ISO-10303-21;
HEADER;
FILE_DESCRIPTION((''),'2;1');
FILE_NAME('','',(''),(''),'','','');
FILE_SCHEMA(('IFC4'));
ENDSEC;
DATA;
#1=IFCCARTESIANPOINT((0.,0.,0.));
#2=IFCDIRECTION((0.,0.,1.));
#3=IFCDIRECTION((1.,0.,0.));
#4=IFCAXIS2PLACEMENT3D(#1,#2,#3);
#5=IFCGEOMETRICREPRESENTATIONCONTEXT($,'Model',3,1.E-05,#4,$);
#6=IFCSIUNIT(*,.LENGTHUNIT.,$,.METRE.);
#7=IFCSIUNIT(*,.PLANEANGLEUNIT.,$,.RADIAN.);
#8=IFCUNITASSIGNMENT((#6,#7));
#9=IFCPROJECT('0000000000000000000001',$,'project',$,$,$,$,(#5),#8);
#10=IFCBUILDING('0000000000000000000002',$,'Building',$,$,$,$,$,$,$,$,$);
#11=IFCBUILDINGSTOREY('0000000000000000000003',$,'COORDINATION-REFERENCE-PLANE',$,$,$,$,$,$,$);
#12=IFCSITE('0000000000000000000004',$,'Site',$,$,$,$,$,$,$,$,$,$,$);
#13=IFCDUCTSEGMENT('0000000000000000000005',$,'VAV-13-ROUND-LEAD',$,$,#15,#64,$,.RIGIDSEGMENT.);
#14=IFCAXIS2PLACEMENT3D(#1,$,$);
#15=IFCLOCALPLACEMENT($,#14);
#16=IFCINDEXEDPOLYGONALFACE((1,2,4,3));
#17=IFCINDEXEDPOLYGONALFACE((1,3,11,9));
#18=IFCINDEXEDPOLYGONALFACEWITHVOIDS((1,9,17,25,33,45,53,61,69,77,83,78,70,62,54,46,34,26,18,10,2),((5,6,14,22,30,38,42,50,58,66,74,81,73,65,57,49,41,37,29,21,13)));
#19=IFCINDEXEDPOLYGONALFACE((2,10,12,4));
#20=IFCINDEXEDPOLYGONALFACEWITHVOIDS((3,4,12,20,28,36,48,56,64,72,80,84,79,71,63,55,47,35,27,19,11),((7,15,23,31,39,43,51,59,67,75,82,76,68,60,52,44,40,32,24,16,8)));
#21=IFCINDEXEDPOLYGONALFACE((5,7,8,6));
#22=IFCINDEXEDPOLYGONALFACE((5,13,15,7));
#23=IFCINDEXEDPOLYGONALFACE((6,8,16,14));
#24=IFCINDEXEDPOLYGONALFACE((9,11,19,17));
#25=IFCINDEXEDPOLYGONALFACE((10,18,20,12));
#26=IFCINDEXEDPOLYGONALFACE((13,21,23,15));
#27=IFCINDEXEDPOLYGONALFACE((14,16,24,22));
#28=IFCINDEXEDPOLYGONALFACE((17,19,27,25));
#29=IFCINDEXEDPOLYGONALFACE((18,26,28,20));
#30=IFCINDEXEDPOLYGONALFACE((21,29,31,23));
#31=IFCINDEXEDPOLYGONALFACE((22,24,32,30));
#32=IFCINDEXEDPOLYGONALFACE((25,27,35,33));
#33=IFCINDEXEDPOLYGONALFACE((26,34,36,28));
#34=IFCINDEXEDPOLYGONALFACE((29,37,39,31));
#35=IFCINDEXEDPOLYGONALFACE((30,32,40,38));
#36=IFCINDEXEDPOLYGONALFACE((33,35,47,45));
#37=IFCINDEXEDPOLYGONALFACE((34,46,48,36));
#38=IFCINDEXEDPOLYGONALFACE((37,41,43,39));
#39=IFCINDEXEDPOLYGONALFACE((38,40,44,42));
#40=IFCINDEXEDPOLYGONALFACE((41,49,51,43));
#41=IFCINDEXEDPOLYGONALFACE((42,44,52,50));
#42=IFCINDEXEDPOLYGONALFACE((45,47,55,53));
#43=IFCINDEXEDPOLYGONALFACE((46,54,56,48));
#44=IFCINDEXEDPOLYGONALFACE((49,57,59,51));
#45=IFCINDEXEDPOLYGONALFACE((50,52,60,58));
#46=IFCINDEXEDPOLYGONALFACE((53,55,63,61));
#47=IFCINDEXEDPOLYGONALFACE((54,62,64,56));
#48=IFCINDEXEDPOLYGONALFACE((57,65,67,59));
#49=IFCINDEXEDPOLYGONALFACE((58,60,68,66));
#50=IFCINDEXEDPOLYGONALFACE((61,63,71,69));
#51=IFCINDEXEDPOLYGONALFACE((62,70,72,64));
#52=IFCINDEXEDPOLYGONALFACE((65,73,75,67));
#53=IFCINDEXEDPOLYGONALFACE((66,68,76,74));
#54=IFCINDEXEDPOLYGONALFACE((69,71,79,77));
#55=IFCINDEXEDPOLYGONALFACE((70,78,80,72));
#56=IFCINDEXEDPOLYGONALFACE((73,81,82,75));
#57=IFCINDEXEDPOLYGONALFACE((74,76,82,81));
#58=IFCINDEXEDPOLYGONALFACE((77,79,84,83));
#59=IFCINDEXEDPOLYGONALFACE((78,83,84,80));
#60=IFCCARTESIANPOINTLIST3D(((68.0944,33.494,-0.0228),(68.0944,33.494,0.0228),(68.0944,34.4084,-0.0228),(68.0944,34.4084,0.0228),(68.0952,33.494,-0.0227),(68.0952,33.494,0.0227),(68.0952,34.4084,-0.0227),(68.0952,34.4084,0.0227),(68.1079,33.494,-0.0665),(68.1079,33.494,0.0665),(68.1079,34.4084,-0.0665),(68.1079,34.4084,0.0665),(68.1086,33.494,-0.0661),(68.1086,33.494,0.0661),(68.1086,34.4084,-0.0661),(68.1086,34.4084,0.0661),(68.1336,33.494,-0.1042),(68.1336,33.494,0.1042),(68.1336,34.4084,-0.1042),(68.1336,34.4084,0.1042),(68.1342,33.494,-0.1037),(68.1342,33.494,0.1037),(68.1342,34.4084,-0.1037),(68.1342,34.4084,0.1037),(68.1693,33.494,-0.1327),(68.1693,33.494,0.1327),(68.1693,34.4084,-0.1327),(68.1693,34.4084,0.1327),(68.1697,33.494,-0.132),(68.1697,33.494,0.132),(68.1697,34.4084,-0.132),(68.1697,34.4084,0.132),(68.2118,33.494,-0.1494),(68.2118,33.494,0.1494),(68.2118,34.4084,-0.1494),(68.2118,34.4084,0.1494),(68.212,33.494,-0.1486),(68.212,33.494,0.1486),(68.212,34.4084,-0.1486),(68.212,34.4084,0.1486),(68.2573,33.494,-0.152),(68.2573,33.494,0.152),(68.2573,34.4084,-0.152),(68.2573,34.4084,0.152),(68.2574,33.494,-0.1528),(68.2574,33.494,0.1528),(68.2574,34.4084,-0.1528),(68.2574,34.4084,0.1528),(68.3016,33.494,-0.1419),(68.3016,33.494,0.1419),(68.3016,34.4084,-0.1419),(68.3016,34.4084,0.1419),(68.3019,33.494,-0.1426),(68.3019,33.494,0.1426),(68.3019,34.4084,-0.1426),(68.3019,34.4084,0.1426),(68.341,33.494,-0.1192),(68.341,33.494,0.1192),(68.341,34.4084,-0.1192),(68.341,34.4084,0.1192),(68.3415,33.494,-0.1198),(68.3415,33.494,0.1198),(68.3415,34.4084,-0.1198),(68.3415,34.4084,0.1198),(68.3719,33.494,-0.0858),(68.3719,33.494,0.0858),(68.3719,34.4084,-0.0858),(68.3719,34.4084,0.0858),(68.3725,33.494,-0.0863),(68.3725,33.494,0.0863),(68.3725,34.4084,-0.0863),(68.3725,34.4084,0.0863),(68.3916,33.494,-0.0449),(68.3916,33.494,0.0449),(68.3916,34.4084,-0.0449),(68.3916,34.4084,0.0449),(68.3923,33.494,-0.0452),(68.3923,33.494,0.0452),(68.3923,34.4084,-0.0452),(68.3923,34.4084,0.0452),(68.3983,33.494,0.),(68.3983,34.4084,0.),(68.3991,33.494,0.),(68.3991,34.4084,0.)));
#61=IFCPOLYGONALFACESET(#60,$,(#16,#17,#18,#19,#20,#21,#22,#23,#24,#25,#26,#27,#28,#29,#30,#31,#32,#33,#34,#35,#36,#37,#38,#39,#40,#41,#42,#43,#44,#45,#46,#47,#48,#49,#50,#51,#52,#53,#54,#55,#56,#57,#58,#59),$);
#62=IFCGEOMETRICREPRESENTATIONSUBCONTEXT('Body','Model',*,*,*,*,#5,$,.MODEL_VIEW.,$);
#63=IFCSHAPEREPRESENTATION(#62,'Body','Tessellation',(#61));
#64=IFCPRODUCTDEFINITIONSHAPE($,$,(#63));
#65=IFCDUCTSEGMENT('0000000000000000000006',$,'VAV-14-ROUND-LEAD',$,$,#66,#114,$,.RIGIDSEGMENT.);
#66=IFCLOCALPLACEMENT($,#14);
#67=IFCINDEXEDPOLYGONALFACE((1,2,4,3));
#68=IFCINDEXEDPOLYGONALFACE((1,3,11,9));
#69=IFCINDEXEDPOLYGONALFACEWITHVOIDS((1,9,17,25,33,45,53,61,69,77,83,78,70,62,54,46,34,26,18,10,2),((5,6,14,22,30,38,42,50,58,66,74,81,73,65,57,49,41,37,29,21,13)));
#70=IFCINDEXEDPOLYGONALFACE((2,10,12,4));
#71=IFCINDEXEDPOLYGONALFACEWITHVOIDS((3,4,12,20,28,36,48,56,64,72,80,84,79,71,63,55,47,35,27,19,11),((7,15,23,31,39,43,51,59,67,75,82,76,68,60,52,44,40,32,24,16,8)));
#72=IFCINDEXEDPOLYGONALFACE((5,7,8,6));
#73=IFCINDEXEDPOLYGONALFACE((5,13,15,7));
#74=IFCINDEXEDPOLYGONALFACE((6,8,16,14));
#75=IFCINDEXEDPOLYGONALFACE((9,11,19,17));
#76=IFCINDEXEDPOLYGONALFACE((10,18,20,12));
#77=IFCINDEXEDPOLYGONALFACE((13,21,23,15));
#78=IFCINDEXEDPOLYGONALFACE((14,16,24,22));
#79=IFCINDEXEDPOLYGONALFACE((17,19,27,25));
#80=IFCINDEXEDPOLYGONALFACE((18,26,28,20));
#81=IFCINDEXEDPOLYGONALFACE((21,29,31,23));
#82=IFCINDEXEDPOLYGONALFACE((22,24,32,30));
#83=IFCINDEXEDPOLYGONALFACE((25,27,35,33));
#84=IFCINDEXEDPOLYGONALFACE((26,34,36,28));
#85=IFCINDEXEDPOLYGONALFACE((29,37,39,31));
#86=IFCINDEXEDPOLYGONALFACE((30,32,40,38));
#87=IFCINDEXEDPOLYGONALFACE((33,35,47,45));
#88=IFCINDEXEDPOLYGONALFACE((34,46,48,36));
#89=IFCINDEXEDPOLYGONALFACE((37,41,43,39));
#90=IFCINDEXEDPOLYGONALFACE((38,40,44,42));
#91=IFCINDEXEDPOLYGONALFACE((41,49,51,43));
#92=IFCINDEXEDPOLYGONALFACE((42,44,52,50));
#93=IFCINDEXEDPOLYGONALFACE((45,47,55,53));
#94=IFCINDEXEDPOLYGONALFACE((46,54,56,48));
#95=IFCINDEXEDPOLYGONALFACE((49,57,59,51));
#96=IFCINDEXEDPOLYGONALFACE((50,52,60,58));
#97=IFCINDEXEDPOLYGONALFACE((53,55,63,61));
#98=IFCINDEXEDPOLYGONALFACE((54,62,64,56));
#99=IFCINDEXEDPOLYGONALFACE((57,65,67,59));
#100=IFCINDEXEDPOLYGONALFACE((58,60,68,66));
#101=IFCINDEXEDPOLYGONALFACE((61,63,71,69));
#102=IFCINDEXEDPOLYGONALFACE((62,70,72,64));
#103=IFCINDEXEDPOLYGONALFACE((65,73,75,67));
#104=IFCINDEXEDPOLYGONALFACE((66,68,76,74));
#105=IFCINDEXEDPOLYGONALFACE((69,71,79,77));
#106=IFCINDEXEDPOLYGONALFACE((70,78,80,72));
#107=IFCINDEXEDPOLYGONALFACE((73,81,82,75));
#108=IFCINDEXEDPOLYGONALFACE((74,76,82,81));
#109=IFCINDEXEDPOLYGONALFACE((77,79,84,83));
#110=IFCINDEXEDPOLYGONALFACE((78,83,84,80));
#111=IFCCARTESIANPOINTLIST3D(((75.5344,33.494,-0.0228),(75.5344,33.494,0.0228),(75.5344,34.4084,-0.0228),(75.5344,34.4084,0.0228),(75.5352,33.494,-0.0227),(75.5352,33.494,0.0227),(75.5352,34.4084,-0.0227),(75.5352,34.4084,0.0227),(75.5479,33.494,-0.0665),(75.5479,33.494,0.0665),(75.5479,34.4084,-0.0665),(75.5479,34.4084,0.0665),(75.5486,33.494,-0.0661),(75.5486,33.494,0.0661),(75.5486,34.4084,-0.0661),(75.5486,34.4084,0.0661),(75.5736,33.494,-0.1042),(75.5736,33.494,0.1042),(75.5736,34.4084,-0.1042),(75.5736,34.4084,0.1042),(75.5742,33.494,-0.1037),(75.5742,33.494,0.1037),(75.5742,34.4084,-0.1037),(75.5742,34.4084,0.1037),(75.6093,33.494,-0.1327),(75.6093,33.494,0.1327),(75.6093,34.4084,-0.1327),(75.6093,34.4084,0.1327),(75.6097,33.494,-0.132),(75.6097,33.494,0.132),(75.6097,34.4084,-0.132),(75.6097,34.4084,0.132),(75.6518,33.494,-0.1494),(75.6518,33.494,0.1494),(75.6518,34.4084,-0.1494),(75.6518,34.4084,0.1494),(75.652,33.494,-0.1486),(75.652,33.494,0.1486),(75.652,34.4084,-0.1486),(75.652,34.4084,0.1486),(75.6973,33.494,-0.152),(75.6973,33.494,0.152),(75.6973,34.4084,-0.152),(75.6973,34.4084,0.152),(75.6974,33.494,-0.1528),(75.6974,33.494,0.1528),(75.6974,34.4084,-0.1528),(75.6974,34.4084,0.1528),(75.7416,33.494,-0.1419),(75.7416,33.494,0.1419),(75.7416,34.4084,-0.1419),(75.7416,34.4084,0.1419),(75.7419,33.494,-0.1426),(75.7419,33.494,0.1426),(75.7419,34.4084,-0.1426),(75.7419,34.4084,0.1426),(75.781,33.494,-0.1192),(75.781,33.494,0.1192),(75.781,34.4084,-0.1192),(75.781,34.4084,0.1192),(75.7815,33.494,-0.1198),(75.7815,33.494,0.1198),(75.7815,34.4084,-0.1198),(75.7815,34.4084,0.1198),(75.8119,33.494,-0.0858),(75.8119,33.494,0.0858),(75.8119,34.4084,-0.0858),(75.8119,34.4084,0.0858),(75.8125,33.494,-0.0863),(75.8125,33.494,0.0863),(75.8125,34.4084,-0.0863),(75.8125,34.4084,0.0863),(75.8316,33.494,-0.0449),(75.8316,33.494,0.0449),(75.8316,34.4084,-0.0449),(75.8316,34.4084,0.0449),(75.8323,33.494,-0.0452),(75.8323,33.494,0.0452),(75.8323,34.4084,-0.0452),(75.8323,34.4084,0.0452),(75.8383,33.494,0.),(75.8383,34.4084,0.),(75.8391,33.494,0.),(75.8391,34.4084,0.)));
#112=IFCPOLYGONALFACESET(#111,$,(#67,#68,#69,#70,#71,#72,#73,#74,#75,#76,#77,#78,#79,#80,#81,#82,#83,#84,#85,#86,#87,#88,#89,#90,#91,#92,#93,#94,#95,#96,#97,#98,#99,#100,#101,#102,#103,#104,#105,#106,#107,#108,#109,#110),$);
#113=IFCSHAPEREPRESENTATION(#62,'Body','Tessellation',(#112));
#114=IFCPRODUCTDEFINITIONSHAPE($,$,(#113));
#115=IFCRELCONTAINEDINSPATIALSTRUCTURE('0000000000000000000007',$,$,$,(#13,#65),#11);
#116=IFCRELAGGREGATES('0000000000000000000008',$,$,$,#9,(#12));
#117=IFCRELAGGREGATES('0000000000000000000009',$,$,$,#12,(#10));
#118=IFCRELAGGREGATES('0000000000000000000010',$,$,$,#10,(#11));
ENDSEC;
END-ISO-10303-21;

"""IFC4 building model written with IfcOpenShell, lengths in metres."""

from ifc_helpers import new_model, si_unit, frame, origin, origin_with_axes, place, context, subcontext, project, spatial, hollow_circle, extrude, element, save


model = new_model("IFC4")

# Units and contexts
model_context = context("Model", 3, precision=1e-05, world=origin_with_axes())
body_context_1 = subcontext(model_context, "Body", "Model", "MODEL_VIEW")
ifc_project = project(units=[si_unit("LENGTHUNIT", "METRE"), si_unit("PLANEANGLEUNIT", "RADIAN")], contexts=[model_context])

# Site, building, storey
site = spatial("IfcSite", under=ifc_project, Name="Site")
building = spatial("IfcBuilding", under=site, Name="Building")
storey = spatial("IfcBuildingStorey", under=building, Name="COORDINATION-REFERENCE-PLANE")

# Duct segments
for number, where, z_axis, x_axis, name in (
    (1, (68.2459, 34.4084, 0.0), (0.0, -1.0, 0.0), (1.0, 0.0, 0.0), "VAV-13-ROUND-LEAD"),
    (2, (75.6859, 34.4084, 0.0), (0.0, -1.0, 0.0), (1.0, 0.0, 0.0), "VAV-14-ROUND-LEAD"),
):
    element("IfcDuctSegment", number, at=place(None, frame(where, z_axis=z_axis, x_axis=x_axis)), inside=storey, Name=name, PredefinedType="RIGIDSEGMENT", context=body_context_1, shape_type="SweptSolid", body=[
        extrude(hollow_circle(Radius=0.1532, WallThickness=0.0008), origin(), (0.0, 0.0, 1.0), 0.9144),
    ])

save(model, "model.ifc")
